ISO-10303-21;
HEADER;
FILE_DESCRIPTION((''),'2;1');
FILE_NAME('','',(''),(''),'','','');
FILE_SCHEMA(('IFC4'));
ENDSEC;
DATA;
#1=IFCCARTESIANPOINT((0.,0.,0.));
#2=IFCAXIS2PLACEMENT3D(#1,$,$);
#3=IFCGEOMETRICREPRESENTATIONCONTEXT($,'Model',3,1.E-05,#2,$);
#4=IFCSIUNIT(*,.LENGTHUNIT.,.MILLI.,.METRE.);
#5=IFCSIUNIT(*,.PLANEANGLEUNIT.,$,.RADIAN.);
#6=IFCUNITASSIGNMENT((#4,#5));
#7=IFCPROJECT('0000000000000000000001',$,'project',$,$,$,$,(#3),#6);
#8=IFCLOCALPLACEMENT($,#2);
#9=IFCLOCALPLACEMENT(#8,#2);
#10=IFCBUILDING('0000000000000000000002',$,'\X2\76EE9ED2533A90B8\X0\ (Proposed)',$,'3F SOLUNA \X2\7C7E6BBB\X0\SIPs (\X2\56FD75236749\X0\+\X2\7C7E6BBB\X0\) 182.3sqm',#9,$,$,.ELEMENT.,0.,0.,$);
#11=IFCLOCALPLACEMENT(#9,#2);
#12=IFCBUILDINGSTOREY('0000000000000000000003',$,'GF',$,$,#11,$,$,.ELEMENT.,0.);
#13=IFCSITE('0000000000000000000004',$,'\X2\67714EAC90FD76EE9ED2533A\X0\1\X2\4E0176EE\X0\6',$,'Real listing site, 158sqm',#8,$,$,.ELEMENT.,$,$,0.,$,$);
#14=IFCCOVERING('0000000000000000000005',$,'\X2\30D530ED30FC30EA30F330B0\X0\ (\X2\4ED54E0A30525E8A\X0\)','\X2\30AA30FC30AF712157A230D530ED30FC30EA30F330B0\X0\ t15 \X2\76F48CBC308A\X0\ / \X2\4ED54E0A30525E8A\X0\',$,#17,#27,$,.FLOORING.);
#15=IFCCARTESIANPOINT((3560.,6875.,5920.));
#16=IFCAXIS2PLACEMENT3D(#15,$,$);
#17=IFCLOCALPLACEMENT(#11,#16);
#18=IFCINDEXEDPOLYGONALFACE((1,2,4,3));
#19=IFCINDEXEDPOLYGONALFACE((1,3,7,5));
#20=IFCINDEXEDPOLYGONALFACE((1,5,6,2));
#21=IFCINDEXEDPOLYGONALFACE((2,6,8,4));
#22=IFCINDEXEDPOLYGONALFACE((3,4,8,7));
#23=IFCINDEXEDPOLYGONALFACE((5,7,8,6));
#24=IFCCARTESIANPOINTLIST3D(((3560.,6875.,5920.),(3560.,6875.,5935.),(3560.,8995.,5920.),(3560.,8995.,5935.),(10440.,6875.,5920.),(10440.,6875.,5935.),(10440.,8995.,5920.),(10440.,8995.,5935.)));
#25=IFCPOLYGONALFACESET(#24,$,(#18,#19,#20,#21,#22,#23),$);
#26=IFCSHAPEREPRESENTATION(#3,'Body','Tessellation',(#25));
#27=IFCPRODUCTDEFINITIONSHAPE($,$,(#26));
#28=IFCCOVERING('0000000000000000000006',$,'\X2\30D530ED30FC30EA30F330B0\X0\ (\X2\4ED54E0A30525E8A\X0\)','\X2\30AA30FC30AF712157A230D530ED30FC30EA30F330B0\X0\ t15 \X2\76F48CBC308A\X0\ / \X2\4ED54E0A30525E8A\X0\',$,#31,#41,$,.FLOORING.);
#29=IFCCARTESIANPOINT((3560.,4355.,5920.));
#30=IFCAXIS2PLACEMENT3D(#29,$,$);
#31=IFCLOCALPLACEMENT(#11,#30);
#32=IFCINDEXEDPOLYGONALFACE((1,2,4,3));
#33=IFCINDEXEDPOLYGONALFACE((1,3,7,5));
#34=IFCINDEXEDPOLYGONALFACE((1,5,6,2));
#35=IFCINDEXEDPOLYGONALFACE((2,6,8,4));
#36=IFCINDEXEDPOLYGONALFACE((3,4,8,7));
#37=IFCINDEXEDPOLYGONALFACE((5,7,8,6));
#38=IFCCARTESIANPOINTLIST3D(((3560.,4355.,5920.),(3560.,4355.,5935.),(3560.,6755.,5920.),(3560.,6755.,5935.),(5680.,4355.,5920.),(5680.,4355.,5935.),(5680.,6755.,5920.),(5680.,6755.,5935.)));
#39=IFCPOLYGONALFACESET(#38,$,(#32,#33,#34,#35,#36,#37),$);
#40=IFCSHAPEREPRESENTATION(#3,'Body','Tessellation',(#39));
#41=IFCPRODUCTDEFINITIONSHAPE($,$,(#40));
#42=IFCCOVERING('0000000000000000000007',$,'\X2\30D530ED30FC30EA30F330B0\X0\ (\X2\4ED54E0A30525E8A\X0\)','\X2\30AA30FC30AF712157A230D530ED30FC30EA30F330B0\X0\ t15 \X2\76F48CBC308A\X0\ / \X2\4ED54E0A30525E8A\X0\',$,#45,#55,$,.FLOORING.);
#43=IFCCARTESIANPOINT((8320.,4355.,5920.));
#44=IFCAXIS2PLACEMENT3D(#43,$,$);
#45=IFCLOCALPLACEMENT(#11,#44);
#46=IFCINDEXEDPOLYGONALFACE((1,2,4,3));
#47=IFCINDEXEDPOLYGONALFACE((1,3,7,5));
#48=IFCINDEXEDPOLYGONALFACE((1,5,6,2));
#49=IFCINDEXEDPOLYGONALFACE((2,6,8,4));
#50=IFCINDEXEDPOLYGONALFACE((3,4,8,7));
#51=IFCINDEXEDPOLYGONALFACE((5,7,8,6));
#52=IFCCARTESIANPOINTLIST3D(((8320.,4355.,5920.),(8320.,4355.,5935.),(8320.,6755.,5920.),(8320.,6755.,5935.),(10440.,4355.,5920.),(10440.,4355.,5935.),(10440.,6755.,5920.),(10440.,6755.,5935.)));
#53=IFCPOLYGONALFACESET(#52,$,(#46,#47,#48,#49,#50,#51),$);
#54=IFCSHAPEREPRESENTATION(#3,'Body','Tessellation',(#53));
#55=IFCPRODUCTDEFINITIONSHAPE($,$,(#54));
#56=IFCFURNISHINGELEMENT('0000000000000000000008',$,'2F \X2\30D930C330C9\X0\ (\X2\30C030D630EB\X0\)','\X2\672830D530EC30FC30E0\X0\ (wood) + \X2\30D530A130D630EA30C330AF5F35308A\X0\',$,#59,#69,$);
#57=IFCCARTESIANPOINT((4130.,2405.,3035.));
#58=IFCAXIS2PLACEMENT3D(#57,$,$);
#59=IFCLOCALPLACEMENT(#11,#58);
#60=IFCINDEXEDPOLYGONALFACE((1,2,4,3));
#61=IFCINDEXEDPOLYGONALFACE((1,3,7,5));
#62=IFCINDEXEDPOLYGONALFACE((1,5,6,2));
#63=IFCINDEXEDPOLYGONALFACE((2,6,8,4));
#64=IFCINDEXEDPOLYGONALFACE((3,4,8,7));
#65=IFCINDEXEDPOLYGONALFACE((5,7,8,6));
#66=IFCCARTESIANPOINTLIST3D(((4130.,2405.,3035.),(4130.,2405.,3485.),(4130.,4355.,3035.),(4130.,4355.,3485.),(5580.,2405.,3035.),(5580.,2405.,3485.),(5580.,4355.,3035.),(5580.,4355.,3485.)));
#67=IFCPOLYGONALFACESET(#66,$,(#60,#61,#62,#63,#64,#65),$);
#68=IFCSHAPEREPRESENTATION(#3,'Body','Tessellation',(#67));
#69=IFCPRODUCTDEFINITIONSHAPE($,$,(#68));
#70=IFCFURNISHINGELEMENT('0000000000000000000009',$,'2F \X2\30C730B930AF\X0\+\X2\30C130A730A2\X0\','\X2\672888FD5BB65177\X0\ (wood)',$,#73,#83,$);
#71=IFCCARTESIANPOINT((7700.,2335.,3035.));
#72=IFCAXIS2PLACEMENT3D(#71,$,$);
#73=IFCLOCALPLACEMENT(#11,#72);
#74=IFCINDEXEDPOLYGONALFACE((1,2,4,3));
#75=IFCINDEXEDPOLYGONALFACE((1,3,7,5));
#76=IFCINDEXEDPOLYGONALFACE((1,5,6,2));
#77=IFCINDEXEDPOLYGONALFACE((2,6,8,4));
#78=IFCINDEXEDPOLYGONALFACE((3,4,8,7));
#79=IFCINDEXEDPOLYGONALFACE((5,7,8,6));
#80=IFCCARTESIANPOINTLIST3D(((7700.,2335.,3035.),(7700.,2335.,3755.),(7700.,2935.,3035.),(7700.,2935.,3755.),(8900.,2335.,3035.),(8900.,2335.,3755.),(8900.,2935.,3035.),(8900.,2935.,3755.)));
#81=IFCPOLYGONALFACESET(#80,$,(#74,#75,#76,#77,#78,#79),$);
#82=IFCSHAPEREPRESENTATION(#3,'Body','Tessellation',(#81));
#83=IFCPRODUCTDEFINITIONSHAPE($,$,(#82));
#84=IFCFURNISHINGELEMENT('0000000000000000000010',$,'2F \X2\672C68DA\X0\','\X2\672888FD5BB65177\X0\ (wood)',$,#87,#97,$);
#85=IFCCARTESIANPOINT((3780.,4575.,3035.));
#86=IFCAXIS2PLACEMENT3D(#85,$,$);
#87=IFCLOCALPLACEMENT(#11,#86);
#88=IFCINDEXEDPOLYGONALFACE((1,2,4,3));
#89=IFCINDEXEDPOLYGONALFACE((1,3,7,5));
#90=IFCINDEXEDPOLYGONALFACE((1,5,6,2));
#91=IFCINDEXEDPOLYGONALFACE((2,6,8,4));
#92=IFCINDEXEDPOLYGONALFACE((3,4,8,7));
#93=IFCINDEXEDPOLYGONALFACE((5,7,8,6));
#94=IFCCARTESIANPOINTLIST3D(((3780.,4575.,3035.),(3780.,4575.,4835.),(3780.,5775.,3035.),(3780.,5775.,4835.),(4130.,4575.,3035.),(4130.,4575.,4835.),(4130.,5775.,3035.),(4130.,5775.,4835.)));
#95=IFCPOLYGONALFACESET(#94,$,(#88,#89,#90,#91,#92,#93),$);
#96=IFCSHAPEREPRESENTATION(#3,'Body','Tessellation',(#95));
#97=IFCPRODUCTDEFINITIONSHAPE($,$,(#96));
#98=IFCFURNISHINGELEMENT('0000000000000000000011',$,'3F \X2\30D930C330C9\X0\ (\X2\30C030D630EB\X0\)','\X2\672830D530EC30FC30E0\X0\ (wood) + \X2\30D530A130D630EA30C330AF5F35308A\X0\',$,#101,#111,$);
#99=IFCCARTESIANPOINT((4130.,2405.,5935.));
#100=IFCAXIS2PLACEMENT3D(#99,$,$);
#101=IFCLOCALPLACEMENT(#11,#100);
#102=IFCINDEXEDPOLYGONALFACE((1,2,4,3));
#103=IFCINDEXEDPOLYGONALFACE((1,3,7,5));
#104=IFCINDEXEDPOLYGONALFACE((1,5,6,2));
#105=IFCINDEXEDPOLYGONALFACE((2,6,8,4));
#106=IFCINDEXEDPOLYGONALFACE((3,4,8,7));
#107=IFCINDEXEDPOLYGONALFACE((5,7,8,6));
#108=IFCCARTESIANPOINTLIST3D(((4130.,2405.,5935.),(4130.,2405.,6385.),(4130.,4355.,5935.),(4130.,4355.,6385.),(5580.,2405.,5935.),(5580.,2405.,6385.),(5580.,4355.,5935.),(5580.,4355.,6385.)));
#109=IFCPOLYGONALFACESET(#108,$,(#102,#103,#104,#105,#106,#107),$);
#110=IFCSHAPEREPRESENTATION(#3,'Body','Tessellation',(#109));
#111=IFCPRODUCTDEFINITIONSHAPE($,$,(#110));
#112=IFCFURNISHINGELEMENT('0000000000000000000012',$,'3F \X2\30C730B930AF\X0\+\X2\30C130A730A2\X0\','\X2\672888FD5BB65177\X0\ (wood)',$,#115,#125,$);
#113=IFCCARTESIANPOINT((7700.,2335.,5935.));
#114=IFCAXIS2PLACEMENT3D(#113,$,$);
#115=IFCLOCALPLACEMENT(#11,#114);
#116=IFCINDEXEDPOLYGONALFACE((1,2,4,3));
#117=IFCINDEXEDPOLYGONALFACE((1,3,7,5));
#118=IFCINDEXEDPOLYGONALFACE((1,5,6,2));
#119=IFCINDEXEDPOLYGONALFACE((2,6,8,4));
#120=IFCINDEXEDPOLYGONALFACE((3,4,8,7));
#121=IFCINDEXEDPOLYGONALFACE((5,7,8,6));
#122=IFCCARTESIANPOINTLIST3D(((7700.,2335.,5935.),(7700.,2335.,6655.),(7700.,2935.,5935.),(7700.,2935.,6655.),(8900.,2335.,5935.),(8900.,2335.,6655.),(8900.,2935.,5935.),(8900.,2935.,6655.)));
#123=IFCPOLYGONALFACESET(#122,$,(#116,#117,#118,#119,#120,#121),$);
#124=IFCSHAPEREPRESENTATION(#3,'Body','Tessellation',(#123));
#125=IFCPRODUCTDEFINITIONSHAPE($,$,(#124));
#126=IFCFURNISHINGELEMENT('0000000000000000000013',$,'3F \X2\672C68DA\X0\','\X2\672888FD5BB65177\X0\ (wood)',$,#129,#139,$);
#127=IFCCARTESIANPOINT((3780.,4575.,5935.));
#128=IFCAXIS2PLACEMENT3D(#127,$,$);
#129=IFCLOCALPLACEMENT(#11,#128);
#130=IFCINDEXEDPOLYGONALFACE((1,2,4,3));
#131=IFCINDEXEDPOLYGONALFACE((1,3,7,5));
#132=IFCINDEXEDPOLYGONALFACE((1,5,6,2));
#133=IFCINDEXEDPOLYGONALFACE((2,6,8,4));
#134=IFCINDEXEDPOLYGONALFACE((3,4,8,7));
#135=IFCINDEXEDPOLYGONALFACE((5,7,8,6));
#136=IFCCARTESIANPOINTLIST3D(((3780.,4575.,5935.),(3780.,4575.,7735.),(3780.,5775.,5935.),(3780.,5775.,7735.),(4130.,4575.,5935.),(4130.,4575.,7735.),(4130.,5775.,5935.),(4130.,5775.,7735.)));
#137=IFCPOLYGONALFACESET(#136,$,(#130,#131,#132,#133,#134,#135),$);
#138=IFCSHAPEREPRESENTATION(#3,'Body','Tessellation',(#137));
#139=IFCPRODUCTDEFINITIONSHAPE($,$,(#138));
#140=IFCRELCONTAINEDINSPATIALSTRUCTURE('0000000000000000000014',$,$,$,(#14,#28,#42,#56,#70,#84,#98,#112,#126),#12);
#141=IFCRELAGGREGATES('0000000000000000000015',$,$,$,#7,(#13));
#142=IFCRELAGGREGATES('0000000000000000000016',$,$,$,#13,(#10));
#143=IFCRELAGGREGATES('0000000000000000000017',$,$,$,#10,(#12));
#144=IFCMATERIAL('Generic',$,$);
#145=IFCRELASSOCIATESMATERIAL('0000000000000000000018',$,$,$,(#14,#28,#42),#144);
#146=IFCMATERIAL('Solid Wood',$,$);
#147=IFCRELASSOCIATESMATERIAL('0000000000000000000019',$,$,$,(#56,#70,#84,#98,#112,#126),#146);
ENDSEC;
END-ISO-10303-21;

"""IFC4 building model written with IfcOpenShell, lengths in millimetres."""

from ifc_helpers import new_model, si_unit, frame, frame_2d, origin, place, context, project, spatial, rectangle, extrude, material, element, save


model = new_model("IFC4")

# Units and contexts
model_context = context("Model", 3, precision=1e-05, world=origin())
ifc_project = project(units=[si_unit("LENGTHUNIT", "METRE", prefix="MILLI"), si_unit("PLANEANGLEUNIT", "RADIAN")], contexts=[model_context])

# Site, building, storey
site_placement = place(None, origin())
site = spatial("IfcSite", under=ifc_project, at=site_placement, Name="東京都目黒区1丁目6", ObjectType="Real listing site, 158sqm", CompositionType="ELEMENT", RefElevation=0.0)
building_placement = place(site_placement, origin())
building = spatial("IfcBuilding", under=site, at=building_placement, Name="目黒区邸 (Proposed)", ObjectType="3F SOLUNA 籾殻SIPs (国産杉+籾殻) 182.3sqm", CompositionType="ELEMENT", ElevationOfRefHeight=0.0, ElevationOfTerrain=0.0)
storey_placement = place(building_placement, origin())
storey = spatial("IfcBuildingStorey", under=building, at=storey_placement, Name="GF", CompositionType="ELEMENT", Elevation=0.0)

# Shared definitions
ifc_material_1 = material(Name="Solid Wood")

# Shared definitions
ifc_material_2 = material(Name="Generic")

# Coverings
covering_1_placement = place(storey_placement, frame((3560.0, 6875.0, 5920.0)))
element("IfcCovering", 1, at=covering_1_placement, inside=storey, material=ifc_material_2, Name="フローリング (仕上げ床)", Description="オーク無垢フローリング t15 直貼り / 仕上げ床", PredefinedType="FLOORING", context=model_context, shape_type="SweptSolid", body=[
    extrude(rectangle(XDim=6880.0, YDim=2120.0, at=frame_2d((3440.0, 1060.0))), frame((3560.0, 6875.0, 5920.0)), (0.0, 0.0, 1.0), 15.0),
])
covering_2_placement = place(storey_placement, frame((3560.0, 4355.0, 5920.0)))
element("IfcCovering", 2, at=covering_2_placement, inside=storey, material=ifc_material_2, Name="フローリング (仕上げ床)", Description="オーク無垢フローリング t15 直貼り / 仕上げ床", PredefinedType="FLOORING", context=model_context, shape_type="SweptSolid", body=[
    extrude(rectangle(XDim=2120.0, YDim=2400.0, at=frame_2d((1060.0, 1200.0))), frame((3560.0, 4355.0, 5920.0)), (0.0, 0.0, 1.0), 15.0),
])
covering_3_placement = place(storey_placement, frame((8320.0, 4355.0, 5920.0)))
element("IfcCovering", 3, at=covering_3_placement, inside=storey, material=ifc_material_2, Name="フローリング (仕上げ床)", Description="オーク無垢フローリング t15 直貼り / 仕上げ床", PredefinedType="FLOORING", context=model_context, shape_type="SweptSolid", body=[
    extrude(rectangle(XDim=2120.0, YDim=2400.0, at=frame_2d((1060.0, 1200.0))), frame((8320.0, 4355.0, 5920.0)), (0.0, 0.0, 1.0), 15.0),
])

# Furnishing elements
furnishing_1_placement = place(storey_placement, frame((4130.0, 2405.0, 3035.0)))
element("IfcFurnishingElement", 4, at=furnishing_1_placement, inside=storey, material=ifc_material_1, Name="2F ベッド (ダブル)", Description="木フレーム (wood) + ファブリック張り", context=model_context, shape_type="SweptSolid", body=[
    extrude(rectangle(XDim=1450.0, YDim=1950.0, at=frame_2d((725.0, 975.0))), frame((4130.0, 2405.0, 3035.0)), (0.0, 0.0, 1.0), 450.0),
])
furnishing_2_placement = place(storey_placement, frame((7700.0, 2335.0, 3035.0)))
element("IfcFurnishingElement", 5, at=furnishing_2_placement, inside=storey, material=ifc_material_1, Name="2F デスク+チェア", Description="木製家具 (wood)", context=model_context, shape_type="SweptSolid", body=[
    extrude(rectangle(XDim=1200.0, YDim=600.0, at=frame_2d((600.0, 300.0))), frame((7700.0, 2335.0, 3035.0)), (0.0, 0.0, 1.0), 720.0),
])
furnishing_3_placement = place(storey_placement, frame((3780.0, 4575.0, 3035.0)))
element("IfcFurnishingElement", 6, at=furnishing_3_placement, inside=storey, material=ifc_material_1, Name="2F 本棚", Description="木製家具 (wood)", context=model_context, shape_type="SweptSolid", body=[
    extrude(rectangle(XDim=350.0, YDim=1200.0, at=frame_2d((175.0, 600.0))), frame((3780.0, 4575.0, 3035.0)), (0.0, 0.0, 1.0), 1800.0),
])
furnishing_4_placement = place(storey_placement, frame((4130.0, 2405.0, 5935.0)))
element("IfcFurnishingElement", 7, at=furnishing_4_placement, inside=storey, material=ifc_material_1, Name="3F ベッド (ダブル)", Description="木フレーム (wood) + ファブリック張り", context=model_context, shape_type="SweptSolid", body=[
    extrude(rectangle(XDim=1450.0, YDim=1950.0, at=frame_2d((725.0, 975.0))), frame((4130.0, 2405.0, 5935.0)), (0.0, 0.0, 1.0), 450.0),
])
furnishing_5_placement = place(storey_placement, frame((7700.0, 2335.0, 5935.0)))
element("IfcFurnishingElement", 8, at=furnishing_5_placement, inside=storey, material=ifc_material_1, Name="3F デスク+チェア", Description="木製家具 (wood)", context=model_context, shape_type="SweptSolid", body=[
    extrude(rectangle(XDim=1200.0, YDim=600.0, at=frame_2d((600.0, 300.0))), frame((7700.0, 2335.0, 5935.0)), (0.0, 0.0, 1.0), 720.0),
])
furnishing_6_placement = place(storey_placement, frame((3780.0, 4575.0, 5935.0)))
element("IfcFurnishingElement", 9, at=furnishing_6_placement, inside=storey, material=ifc_material_1, Name="3F 本棚", Description="木製家具 (wood)", context=model_context, shape_type="SweptSolid", body=[
    extrude(rectangle(XDim=350.0, YDim=1200.0, at=frame_2d((175.0, 600.0))), frame((3780.0, 4575.0, 5935.0)), (0.0, 0.0, 1.0), 1800.0),
])

save(model, "model.ifc")
